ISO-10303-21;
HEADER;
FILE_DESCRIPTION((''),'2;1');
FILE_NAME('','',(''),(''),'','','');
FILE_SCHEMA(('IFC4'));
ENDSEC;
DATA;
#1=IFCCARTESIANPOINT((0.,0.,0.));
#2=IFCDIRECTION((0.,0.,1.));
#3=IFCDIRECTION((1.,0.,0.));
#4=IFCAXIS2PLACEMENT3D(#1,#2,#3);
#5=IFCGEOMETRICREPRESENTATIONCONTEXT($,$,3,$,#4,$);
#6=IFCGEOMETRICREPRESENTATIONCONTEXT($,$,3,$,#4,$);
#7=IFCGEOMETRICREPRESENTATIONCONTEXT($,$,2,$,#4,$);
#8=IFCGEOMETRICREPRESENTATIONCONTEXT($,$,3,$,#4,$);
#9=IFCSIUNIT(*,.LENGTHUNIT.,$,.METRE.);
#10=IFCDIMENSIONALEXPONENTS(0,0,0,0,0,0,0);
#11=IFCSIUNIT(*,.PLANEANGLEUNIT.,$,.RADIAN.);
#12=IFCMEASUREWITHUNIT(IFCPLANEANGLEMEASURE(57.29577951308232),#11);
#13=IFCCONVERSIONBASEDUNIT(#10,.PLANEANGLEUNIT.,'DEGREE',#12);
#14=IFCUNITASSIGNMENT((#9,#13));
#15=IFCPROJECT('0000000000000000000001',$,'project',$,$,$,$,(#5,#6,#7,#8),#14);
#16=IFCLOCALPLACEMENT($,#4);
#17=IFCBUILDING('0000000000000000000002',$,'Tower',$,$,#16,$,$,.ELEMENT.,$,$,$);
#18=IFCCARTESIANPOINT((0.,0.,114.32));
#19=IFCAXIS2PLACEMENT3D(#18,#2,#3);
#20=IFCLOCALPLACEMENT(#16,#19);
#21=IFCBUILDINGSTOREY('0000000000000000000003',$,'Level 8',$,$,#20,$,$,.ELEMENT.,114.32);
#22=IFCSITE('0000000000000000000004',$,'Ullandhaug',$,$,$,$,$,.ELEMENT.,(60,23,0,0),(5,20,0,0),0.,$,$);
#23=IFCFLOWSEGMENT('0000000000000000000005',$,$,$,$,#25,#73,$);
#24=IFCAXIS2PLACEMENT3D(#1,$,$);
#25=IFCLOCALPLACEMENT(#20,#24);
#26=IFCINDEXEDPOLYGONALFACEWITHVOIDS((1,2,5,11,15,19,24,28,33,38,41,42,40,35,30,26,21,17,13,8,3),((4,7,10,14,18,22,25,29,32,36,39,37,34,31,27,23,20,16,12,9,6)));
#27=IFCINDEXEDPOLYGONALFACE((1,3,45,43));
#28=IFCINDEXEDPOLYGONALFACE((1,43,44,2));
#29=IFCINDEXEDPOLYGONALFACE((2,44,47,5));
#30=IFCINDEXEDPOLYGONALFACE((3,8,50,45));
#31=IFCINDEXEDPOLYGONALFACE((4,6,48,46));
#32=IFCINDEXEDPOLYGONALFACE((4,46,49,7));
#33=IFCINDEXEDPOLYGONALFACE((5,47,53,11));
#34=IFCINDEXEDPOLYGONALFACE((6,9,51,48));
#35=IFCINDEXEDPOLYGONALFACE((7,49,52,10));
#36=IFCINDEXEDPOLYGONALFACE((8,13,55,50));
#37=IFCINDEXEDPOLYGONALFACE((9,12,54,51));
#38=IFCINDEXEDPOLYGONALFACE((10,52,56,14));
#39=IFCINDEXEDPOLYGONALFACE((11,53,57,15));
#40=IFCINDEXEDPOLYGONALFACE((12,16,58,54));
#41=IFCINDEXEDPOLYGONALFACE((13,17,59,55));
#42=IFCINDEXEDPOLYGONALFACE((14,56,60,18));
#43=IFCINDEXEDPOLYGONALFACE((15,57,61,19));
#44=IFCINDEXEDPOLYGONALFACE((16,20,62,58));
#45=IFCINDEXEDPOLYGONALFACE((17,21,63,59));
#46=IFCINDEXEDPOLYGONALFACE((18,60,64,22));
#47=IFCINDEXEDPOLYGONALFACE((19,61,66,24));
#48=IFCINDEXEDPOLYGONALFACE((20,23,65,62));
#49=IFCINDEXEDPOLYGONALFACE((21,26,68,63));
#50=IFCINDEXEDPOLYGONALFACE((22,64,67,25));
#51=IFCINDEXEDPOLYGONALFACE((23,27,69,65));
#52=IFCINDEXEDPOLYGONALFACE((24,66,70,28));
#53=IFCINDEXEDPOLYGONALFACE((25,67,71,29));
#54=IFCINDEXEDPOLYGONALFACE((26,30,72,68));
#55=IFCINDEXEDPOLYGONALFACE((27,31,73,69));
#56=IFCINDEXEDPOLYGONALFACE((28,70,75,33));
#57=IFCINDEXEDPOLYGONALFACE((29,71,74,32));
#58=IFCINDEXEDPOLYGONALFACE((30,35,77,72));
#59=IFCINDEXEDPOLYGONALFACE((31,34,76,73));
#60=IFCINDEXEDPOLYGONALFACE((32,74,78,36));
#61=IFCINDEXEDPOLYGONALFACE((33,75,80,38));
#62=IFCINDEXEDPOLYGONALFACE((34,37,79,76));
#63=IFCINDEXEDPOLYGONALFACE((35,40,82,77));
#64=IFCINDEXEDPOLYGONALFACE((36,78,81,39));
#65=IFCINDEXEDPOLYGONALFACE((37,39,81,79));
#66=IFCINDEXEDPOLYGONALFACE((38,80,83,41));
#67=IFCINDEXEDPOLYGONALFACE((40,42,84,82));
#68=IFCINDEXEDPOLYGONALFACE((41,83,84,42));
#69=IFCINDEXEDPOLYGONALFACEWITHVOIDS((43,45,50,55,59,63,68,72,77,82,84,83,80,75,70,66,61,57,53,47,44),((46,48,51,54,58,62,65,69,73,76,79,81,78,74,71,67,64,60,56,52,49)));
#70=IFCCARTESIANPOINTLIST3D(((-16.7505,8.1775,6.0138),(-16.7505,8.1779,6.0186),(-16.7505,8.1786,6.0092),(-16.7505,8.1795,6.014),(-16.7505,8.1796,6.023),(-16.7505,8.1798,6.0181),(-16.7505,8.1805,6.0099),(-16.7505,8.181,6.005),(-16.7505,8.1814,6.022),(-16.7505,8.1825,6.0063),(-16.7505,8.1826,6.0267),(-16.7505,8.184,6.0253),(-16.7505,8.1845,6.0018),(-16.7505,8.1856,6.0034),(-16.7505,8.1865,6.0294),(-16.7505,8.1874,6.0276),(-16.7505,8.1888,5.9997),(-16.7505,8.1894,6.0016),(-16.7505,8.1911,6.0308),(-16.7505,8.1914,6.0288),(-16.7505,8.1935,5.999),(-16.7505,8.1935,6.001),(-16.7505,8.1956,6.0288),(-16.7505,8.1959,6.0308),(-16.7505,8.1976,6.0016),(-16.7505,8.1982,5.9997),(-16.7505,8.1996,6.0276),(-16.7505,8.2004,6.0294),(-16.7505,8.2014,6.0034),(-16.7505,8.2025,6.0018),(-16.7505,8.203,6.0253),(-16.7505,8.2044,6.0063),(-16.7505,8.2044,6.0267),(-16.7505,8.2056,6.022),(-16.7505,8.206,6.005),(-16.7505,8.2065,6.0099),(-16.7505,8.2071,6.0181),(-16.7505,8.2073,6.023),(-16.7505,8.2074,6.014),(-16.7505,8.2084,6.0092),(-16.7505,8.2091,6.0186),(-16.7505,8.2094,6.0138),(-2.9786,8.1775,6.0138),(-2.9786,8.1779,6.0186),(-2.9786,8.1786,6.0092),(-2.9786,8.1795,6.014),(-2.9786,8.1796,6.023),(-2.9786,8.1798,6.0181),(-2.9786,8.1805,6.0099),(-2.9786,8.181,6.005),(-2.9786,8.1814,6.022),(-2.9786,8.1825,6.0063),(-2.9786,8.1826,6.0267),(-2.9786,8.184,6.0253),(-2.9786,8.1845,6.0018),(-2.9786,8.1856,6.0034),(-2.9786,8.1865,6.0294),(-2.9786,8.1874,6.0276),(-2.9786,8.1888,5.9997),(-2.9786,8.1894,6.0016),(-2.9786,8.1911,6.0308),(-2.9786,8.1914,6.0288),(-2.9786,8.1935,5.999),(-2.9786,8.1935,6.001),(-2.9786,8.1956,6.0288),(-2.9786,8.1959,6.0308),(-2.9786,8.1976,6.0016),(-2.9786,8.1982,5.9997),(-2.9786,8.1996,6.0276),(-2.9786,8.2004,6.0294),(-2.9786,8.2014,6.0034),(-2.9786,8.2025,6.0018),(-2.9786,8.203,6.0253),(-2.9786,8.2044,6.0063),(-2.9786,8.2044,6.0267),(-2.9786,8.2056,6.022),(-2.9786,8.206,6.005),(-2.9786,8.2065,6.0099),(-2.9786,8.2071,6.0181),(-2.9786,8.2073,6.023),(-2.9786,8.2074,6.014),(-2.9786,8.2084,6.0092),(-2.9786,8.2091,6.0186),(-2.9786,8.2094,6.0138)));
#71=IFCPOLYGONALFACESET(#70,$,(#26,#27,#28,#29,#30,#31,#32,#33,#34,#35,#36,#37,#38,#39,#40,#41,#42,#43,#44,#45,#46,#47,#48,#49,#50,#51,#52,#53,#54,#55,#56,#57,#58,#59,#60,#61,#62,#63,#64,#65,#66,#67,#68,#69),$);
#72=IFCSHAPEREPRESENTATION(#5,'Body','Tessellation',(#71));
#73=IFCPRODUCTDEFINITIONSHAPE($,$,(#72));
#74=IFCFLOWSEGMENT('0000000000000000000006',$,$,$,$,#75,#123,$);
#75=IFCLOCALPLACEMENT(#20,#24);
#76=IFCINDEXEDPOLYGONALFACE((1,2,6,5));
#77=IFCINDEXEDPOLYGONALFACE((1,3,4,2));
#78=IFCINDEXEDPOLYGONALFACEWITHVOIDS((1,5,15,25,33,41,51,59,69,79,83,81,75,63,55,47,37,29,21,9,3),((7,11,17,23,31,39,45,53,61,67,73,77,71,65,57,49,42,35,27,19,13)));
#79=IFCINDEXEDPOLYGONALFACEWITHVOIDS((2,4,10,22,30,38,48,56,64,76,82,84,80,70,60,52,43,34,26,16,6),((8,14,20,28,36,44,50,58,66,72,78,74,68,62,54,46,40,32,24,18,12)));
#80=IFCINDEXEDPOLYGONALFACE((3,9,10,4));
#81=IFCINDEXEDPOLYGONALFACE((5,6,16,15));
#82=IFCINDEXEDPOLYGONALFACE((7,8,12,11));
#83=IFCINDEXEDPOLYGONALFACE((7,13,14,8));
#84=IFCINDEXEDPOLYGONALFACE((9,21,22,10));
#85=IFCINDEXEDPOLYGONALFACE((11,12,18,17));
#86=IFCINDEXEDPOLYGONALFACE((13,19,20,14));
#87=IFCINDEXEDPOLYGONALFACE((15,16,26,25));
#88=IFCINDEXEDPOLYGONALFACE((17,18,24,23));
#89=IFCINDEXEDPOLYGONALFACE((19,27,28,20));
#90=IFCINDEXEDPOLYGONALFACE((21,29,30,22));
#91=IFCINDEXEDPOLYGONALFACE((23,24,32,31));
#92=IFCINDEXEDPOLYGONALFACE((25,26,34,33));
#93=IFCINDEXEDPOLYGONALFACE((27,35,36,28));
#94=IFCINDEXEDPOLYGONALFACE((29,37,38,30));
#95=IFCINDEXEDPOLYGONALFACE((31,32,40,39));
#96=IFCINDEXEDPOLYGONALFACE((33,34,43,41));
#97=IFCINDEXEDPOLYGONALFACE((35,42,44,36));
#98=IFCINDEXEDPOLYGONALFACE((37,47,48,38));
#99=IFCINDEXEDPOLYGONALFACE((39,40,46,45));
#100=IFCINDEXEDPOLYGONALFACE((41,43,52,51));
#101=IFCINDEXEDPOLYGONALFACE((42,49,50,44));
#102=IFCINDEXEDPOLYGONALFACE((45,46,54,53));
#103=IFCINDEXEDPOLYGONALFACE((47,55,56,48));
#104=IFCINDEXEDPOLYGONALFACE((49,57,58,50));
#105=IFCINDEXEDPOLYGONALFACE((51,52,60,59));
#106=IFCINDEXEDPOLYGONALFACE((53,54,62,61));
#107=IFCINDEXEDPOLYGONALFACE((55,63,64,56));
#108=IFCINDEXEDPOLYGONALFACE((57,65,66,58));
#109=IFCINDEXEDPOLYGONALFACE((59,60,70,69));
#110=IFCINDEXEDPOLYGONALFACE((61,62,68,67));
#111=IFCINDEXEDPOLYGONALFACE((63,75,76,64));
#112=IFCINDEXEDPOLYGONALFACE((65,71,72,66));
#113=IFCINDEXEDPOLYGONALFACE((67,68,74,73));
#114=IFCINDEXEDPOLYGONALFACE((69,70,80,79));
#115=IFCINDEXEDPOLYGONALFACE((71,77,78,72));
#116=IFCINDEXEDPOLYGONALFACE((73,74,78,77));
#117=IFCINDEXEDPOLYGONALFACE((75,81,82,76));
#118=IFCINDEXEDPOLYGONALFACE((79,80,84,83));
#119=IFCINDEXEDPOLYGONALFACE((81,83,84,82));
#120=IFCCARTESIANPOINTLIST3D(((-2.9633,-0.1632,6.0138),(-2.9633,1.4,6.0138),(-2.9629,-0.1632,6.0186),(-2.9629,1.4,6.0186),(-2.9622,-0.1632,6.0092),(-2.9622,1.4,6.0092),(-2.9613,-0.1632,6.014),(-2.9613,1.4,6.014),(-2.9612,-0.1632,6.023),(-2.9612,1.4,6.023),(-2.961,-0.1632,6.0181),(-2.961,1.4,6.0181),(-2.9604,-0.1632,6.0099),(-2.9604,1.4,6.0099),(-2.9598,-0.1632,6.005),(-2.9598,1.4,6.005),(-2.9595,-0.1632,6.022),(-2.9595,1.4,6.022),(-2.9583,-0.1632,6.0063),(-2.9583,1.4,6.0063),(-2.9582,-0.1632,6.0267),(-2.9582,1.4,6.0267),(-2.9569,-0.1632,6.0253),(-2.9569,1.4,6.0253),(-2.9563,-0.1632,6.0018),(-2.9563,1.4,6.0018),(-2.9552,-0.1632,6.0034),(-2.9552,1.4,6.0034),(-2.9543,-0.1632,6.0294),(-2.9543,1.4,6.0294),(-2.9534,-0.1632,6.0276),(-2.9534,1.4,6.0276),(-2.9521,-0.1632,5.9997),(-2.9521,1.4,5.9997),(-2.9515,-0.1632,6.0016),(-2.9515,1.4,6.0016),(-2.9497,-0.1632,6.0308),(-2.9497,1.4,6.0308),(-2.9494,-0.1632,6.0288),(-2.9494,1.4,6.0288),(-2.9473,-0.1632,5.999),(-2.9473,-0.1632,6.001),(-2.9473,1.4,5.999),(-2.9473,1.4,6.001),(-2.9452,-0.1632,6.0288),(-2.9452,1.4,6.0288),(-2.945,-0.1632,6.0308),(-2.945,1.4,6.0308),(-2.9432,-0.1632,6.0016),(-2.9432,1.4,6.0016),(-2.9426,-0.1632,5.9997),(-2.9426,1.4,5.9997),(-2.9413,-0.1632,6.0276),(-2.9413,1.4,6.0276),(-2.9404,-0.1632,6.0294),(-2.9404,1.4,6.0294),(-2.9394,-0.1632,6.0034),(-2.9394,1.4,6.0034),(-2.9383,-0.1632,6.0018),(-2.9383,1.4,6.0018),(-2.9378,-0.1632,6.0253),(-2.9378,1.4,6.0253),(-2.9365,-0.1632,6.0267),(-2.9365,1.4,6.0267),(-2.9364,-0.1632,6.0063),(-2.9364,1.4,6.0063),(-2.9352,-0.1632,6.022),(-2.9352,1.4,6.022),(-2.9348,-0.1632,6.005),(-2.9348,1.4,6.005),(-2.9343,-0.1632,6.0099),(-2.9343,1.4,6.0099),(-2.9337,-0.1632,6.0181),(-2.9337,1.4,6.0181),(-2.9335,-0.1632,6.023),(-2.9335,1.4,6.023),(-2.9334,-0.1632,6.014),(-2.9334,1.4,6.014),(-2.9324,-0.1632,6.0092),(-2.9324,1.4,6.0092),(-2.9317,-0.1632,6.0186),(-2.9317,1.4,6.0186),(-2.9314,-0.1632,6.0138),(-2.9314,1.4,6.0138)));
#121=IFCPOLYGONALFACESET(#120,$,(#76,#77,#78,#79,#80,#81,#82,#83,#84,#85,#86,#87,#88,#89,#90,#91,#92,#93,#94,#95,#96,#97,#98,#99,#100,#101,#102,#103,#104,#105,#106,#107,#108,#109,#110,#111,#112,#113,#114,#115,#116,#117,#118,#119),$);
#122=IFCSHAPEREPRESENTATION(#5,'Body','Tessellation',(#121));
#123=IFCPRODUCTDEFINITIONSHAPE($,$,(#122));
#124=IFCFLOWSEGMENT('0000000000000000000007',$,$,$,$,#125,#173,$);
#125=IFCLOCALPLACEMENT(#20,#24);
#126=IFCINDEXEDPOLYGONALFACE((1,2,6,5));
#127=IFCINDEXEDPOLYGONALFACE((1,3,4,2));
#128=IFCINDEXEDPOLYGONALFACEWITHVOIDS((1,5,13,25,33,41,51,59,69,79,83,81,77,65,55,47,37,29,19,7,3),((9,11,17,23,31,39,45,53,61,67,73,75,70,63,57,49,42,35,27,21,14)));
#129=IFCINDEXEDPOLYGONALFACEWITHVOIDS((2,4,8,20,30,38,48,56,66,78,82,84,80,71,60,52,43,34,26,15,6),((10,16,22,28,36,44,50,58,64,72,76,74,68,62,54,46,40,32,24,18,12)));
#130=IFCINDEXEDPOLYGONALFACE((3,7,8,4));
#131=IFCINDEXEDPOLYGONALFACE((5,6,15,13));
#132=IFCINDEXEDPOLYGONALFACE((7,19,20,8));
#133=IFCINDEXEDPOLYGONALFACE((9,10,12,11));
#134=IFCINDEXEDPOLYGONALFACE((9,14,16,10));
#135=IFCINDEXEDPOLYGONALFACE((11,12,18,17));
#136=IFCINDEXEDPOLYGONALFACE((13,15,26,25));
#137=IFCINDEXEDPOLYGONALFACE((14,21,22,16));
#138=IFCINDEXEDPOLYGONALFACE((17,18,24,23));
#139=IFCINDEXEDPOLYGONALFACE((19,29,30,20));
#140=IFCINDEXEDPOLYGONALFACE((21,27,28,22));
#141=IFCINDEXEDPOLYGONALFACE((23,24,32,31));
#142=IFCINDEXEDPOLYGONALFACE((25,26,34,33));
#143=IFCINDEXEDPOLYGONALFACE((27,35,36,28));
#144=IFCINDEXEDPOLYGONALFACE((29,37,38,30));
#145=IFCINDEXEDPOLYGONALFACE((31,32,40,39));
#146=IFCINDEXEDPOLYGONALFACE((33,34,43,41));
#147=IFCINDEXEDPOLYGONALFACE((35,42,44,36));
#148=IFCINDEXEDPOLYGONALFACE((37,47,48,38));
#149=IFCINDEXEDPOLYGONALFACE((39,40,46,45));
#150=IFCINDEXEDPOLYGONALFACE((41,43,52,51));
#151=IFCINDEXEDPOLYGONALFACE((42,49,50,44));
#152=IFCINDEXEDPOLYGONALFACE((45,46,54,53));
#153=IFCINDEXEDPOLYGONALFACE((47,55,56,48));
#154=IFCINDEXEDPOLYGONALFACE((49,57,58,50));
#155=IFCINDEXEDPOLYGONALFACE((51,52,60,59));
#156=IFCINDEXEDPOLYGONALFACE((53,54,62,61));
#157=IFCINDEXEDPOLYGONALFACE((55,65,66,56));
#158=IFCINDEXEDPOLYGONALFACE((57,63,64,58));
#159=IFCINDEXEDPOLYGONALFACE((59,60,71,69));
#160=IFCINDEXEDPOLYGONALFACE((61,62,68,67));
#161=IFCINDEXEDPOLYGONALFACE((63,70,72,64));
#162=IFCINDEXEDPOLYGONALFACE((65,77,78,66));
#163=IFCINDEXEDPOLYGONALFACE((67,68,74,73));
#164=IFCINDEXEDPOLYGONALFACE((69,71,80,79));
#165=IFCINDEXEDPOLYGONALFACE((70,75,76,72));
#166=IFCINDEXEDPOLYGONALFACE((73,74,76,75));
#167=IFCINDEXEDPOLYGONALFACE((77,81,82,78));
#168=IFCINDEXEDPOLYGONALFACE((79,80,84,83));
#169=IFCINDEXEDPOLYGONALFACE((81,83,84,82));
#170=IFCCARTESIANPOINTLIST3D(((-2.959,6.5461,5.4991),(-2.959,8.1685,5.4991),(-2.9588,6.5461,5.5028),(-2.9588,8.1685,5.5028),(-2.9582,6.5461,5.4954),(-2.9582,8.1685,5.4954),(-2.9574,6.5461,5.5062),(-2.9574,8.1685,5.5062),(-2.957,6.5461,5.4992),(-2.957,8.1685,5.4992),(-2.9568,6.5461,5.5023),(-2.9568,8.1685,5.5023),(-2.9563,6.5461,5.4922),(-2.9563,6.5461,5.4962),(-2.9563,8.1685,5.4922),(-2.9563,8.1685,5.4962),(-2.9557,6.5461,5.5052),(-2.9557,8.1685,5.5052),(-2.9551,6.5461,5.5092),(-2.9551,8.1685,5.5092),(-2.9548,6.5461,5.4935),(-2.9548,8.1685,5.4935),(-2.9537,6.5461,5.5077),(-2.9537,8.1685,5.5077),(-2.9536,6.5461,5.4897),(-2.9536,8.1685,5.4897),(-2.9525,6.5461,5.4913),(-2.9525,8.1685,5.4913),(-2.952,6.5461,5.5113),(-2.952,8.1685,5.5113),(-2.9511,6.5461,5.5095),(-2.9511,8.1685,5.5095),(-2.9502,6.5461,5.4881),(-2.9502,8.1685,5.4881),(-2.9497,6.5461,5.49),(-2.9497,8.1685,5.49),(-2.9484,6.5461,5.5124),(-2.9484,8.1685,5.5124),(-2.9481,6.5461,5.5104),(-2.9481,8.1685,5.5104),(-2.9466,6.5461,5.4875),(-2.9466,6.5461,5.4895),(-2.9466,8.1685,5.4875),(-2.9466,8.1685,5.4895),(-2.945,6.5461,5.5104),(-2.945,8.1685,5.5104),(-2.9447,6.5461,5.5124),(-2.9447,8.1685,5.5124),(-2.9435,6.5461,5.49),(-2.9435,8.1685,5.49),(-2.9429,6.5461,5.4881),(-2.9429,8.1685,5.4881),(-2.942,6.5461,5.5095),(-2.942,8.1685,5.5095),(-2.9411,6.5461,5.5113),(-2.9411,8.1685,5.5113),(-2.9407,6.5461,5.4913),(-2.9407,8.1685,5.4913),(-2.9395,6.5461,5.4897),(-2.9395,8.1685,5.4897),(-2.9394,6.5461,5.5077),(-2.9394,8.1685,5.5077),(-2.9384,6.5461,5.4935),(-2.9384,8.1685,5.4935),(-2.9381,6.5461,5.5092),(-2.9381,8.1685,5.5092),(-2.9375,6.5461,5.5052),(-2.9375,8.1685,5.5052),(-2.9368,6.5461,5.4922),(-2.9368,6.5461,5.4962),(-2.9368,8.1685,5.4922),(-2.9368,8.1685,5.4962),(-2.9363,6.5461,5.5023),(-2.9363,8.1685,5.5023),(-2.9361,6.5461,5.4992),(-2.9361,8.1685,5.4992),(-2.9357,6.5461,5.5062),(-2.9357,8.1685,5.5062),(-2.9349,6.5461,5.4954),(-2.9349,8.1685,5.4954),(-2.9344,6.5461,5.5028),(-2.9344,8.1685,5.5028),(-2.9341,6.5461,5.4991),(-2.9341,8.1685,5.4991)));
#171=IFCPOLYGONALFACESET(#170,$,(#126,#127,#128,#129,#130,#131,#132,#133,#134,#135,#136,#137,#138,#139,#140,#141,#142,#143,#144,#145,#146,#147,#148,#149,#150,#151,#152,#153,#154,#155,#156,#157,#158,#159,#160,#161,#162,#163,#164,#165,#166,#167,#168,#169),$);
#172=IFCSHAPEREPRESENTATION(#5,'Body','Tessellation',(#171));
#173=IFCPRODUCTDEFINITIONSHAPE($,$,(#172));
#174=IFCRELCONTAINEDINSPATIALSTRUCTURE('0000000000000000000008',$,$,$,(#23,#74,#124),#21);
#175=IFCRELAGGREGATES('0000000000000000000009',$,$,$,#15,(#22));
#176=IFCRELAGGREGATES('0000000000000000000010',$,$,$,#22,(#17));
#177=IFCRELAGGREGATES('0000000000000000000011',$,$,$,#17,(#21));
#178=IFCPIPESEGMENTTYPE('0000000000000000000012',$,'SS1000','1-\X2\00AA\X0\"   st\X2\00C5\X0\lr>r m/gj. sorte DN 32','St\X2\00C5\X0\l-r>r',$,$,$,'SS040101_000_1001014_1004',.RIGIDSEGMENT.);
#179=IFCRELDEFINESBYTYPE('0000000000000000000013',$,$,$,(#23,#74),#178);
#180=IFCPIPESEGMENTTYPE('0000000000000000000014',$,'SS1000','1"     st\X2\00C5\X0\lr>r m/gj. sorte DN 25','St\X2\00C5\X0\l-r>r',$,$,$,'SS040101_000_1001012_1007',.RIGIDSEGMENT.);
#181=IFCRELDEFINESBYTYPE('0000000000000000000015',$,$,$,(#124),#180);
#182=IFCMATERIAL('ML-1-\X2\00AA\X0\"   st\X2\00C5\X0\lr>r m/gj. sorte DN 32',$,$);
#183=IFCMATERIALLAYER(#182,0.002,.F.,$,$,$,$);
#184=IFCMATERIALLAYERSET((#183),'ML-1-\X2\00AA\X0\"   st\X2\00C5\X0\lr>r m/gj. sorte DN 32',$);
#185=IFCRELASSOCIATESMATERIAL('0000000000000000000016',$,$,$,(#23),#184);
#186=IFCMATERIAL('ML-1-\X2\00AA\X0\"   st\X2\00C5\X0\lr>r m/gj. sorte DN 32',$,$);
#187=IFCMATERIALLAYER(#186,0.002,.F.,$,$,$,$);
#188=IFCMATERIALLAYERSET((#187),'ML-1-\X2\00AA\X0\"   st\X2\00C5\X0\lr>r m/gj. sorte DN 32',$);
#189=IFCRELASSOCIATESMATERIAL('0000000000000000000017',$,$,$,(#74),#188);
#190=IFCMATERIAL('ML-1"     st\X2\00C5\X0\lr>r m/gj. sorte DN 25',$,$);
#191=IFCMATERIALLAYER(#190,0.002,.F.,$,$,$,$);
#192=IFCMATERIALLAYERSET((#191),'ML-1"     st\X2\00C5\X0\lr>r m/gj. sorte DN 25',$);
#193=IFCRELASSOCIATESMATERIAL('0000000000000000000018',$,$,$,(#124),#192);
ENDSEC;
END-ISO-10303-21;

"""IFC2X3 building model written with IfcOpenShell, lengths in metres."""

from ifc_helpers import new_model, entity, si_unit, converted_unit, frame, origin_with_axes, origin_2d_with_axis, place, context, project, spatial, hollow_circle, extrude, material, layer, layer_set, layer_usage, type_object, element, save


model = new_model("IFC2X3")

# Units and contexts
context_of_model_1 = context(None, 3, world=origin_with_axes())
context_of_model_2 = context(None, 3, world=origin_with_axes())
context_of_model_3 = context(None, 2, world=origin_with_axes())
context_of_model_4 = context(None, 3, world=origin_with_axes())
ifc_project = project(units=[si_unit("LENGTHUNIT", "METRE"), converted_unit("PLANEANGLEUNIT", "DEGREE", entity("IfcPlaneAngleMeasure", 57.29577951308232), si_unit("PLANEANGLEUNIT", "RADIAN"), dimensions=[0, 0, 0, 0, 0, 0, 0])], contexts=[context_of_model_1, context_of_model_2, context_of_model_3, context_of_model_4])

# Site, building, storey
site = spatial("IfcSite", under=ifc_project, Name="Ullandhaug", CompositionType="ELEMENT", RefLatitude=(60, 23, 0, 0), RefLongitude=(5, 20, 0, 0), RefElevation=0.0)
building_placement = place(None, origin_with_axes())
building = spatial("IfcBuilding", under=site, at=building_placement, Name="Tower", CompositionType="ELEMENT")
storey_placement = place(building_placement, frame((0.0, 0.0, 114.32), z_axis=(0.0, 0.0, 1.0), x_axis=(1.0, 0.0, 0.0)))
storey = spatial("IfcBuildingStorey", under=building, at=storey_placement, Name="Level 8", CompositionType="ELEMENT", Elevation=114.32)

# Flow segments
pipe_segment_type_1 = type_object("IfcPipeSegmentType", Name="SS1000", Description="1-ª\"   stÅlr>r m/gj. sorte DN 32", ApplicableOccurrence="StÅl-r>r", ElementType="SS040101_000_1001014_1004", PredefinedType="RIGIDSEGMENT")
ifc_material_1 = material(Name="ML-1-ª\"   stÅlr>r m/gj. sorte DN 32")
ifc_layer_1 = layer(ifc_material_1, 0.002, ventilated=False)
ifc_layer_set_1 = layer_set([ifc_layer_1], Name="ML-1-ª\"   stÅlr>r m/gj. sorte DN 32")
ifc_layer_usage_1 = layer_usage(ifc_layer_set_1, "AXIS2", "POSITIVE", 0.0)
flow_segment_1_placement = place(storey_placement, frame((-2.9786, 8.1935, 6.015), z_axis=(-1.0, 0.0, 0.0), x_axis=(0.0, 0.0, -1.0)))
element("IfcFlowSegment", 1, at=flow_segment_1_placement, inside=storey, type_object=pipe_segment_type_1, material=ifc_layer_usage_1, context=context_of_model_1, shape_type="SweptSolid", body=[
    extrude(hollow_circle(Radius=0.016, WallThickness=0.002, at=origin_2d_with_axis()), origin_with_axes(), (0.0, 0.0, 1.0), 13.7719),
])
ifc_material_2 = material(Name="ML-1-ª\"   stÅlr>r m/gj. sorte DN 32")
ifc_layer_2 = layer(ifc_material_2, 0.002, ventilated=False)
ifc_layer_set_2 = layer_set([ifc_layer_2], Name="ML-1-ª\"   stÅlr>r m/gj. sorte DN 32")
ifc_layer_usage_2 = layer_usage(ifc_layer_set_2, "AXIS2", "POSITIVE", 0.0)
flow_segment_2_placement = place(storey_placement, frame((-2.9473, -0.1632, 6.015), z_axis=(0.0, 1.0, 0.0), x_axis=(0.0, 0.0, -1.0)))
element("IfcFlowSegment", 2, at=flow_segment_2_placement, inside=storey, type_object=pipe_segment_type_1, material=ifc_layer_usage_2, context=context_of_model_1, shape_type="SweptSolid", body=[
    extrude(hollow_circle(Radius=0.016, WallThickness=0.002, at=origin_2d_with_axis()), origin_with_axes(), (0.0, 0.0, 1.0), 1.5632),
])
ifc_material_3 = material(Name="ML-1\"     stÅlr>r m/gj. sorte DN 25")
ifc_layer_3 = layer(ifc_material_3, 0.002, ventilated=False)
ifc_layer_set_3 = layer_set([ifc_layer_3], Name="ML-1\"     stÅlr>r m/gj. sorte DN 25")
ifc_layer_usage_3 = layer_usage(ifc_layer_set_3, "AXIS2", "POSITIVE", 0.0)
pipe_segment_type_2 = type_object("IfcPipeSegmentType", Name="SS1000", Description="1\"     stÅlr>r m/gj. sorte DN 25", ApplicableOccurrence="StÅl-r>r", ElementType="SS040101_000_1001012_1007", PredefinedType="RIGIDSEGMENT")
flow_segment_3_placement = place(storey_placement, frame((-2.9466, 6.5461, 5.5), z_axis=(0.0, 1.0, 0.0), x_axis=(0.0, 0.0, -1.0)))
element("IfcFlowSegment", 3, at=flow_segment_3_placement, inside=storey, type_object=pipe_segment_type_2, material=ifc_layer_usage_3, context=context_of_model_1, shape_type="SweptSolid", body=[
    extrude(hollow_circle(Radius=0.0125, WallThickness=0.002, at=origin_2d_with_axis()), origin_with_axes(), (0.0, 0.0, 1.0), 1.6224),
])

save(model, "model.ifc")
